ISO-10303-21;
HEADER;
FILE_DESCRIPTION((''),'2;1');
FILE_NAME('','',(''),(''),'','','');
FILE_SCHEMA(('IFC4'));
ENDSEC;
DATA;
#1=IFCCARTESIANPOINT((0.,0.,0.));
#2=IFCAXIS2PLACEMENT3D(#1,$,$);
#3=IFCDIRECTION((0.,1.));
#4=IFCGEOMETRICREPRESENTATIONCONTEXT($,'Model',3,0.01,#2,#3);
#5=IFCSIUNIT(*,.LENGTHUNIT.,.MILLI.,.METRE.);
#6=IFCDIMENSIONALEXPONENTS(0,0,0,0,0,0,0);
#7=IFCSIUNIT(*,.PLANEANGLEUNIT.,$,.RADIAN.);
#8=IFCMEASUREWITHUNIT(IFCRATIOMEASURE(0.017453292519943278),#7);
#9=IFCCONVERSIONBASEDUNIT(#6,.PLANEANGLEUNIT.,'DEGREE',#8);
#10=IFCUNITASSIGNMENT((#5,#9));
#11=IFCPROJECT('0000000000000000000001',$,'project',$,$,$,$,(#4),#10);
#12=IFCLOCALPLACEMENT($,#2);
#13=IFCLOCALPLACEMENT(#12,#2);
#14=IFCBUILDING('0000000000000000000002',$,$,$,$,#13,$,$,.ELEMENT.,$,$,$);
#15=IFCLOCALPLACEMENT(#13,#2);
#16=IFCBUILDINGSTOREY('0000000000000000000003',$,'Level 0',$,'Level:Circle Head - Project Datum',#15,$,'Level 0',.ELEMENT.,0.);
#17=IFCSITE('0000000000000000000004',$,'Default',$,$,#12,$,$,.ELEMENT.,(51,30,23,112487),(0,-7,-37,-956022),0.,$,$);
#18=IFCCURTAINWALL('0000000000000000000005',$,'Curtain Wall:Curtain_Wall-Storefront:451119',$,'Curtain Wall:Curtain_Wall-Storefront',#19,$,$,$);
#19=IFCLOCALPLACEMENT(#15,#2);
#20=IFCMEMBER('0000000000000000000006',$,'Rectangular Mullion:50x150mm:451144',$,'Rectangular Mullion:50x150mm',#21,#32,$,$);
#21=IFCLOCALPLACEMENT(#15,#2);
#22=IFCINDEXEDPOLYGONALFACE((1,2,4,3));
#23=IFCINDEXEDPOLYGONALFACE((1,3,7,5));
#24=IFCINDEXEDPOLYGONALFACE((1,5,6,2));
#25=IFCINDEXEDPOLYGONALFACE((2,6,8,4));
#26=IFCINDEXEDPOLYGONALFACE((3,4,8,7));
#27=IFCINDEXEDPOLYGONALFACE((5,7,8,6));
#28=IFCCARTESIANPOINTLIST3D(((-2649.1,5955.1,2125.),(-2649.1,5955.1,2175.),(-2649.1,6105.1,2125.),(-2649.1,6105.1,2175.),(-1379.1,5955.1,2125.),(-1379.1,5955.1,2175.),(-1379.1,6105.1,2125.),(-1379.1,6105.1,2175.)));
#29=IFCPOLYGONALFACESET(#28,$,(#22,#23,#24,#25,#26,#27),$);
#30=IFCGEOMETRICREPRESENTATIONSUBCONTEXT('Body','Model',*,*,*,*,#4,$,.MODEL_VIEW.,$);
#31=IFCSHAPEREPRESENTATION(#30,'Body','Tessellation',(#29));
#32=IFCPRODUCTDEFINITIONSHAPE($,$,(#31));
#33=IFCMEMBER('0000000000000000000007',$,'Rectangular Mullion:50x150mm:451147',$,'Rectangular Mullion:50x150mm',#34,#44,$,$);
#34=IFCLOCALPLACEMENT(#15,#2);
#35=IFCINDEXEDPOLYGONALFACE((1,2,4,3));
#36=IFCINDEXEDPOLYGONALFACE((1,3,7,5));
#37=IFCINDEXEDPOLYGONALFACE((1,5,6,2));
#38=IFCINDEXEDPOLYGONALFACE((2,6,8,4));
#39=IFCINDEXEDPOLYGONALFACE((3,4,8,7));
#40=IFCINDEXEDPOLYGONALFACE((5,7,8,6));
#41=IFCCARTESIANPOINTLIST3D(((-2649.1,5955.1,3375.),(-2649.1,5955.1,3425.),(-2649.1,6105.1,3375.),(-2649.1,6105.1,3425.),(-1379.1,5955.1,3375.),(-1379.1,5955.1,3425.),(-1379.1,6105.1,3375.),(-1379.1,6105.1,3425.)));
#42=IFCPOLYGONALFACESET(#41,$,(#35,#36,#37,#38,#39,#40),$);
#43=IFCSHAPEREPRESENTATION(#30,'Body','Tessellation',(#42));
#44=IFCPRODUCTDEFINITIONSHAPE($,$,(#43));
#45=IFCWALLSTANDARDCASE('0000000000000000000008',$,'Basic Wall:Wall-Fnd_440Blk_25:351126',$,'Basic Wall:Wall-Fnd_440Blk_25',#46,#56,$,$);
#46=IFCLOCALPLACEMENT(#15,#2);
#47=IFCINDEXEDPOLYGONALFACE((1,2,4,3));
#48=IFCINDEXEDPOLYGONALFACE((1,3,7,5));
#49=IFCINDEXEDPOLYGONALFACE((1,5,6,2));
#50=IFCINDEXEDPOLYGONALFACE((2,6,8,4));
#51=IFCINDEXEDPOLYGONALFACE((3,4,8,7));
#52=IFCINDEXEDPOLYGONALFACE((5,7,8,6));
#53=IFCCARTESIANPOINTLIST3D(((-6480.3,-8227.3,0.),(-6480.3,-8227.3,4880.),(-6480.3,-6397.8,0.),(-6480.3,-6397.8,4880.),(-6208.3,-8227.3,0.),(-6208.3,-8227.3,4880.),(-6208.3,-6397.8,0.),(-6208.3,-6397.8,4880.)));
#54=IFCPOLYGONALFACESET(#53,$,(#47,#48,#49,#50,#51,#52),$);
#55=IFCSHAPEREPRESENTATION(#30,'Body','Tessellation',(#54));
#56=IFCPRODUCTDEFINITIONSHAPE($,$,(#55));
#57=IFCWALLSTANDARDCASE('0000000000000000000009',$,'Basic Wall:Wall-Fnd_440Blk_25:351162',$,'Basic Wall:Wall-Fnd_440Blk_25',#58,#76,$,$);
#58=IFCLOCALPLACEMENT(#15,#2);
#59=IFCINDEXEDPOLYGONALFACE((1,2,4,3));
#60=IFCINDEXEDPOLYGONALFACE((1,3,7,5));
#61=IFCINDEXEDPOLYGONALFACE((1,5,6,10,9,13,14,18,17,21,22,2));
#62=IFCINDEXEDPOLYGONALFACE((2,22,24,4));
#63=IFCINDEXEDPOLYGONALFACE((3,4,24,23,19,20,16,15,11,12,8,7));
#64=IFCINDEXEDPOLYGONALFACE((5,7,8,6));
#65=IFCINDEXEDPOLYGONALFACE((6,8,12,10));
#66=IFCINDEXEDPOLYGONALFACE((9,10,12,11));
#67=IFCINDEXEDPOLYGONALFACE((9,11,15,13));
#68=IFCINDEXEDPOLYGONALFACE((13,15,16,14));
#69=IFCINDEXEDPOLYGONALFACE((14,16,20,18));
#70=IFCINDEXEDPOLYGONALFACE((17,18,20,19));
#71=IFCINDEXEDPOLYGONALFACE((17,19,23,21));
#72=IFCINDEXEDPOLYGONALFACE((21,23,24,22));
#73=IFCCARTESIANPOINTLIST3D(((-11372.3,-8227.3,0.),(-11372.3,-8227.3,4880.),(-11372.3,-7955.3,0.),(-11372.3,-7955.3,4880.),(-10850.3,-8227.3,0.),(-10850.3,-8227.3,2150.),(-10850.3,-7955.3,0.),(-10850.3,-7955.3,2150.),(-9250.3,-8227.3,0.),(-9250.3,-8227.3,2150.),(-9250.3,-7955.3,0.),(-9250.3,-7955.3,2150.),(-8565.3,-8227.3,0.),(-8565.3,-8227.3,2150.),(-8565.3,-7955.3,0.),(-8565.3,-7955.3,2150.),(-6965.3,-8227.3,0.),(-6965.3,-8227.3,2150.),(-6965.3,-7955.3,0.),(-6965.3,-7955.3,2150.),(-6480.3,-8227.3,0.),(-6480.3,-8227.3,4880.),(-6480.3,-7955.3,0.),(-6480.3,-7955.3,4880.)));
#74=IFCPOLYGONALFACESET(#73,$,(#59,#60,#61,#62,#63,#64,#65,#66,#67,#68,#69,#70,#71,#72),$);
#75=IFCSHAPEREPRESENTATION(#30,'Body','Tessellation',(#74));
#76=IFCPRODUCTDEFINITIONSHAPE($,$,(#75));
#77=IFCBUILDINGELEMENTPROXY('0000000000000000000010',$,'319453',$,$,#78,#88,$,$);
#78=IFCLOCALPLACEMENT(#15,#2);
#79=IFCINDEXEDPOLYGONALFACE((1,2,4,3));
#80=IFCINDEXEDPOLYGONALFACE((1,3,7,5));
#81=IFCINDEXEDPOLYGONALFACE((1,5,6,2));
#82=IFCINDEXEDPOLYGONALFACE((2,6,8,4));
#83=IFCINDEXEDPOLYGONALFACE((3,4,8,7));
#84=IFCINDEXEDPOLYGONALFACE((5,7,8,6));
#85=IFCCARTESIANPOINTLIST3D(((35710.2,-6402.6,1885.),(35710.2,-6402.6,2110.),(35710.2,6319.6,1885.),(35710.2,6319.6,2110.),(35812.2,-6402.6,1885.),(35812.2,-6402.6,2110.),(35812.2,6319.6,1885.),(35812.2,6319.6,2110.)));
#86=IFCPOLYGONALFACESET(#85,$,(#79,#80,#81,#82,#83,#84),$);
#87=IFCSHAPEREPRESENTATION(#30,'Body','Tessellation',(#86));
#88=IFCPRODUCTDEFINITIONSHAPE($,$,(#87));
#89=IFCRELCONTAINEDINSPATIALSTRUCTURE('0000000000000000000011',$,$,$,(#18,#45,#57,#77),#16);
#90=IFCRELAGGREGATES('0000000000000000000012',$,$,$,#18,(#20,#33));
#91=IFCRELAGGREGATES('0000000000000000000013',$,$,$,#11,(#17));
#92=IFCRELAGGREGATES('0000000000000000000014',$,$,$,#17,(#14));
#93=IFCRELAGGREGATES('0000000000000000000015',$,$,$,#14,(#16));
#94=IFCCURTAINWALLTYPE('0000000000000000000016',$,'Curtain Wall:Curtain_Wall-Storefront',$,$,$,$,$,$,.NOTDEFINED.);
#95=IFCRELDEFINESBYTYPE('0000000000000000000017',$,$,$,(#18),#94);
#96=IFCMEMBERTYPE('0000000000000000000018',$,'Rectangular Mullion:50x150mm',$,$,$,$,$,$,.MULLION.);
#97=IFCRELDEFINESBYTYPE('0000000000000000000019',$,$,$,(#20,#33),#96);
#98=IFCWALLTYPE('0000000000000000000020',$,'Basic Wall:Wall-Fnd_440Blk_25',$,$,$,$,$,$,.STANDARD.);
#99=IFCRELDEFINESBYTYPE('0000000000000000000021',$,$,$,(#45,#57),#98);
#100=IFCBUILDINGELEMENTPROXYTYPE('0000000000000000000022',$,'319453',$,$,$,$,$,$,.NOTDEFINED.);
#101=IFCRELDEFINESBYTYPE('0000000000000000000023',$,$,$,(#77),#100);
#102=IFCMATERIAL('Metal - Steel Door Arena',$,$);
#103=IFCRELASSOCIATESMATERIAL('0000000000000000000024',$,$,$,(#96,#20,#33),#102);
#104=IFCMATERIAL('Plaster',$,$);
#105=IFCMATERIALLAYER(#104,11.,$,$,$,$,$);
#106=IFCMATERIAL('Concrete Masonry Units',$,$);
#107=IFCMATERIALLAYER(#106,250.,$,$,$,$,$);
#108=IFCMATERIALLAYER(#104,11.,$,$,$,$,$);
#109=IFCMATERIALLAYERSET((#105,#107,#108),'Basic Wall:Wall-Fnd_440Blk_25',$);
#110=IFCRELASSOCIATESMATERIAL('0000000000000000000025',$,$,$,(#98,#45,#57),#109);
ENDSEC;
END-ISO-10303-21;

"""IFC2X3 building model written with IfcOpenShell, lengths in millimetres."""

from ifc_helpers import new_model, entity, si_unit, converted_unit, direction, frame, frame_2d, origin, origin_2d_with_axis, place, context, subcontext, project, spatial, polyline, rectangle, extrude, clip, bounded_halfspace, source, transform, mapped, material, layer, layer_set, layer_usage, type_object, type_shapes, element, aggregate, save


model = new_model("IFC2X3")

# Units and contexts
model_context = context("Model", 3, precision=0.01, world=origin(), true_north=direction((0.0, 1.0)))
body_context = subcontext(model_context, "Body", "Model", "MODEL_VIEW")
ifc_project = project(units=[si_unit("LENGTHUNIT", "METRE", prefix="MILLI"), converted_unit("PLANEANGLEUNIT", "DEGREE", entity("IfcRatioMeasure", 0.017453292519943278), si_unit("PLANEANGLEUNIT", "RADIAN"), dimensions=[0, 0, 0, 0, 0, 0, 0])], contexts=[model_context])

# Site, building, storey
site_placement = place(None, origin())
site = spatial("IfcSite", under=ifc_project, at=site_placement, Name="Default", CompositionType="ELEMENT", RefLatitude=(51, 30, 23, 112487), RefLongitude=(0, -7, -37, -956022), RefElevation=0.0)
building_placement = place(site_placement, origin())
building = spatial("IfcBuilding", under=site, at=building_placement, CompositionType="ELEMENT")
storey_placement = place(building_placement, origin())
storey = spatial("IfcBuildingStorey", under=building, at=storey_placement, Name="Level 0", ObjectType="Level:Circle Head - Project Datum", LongName="Level 0", CompositionType="ELEMENT", Elevation=0.0)

# Shared definitions
ifc_material_1 = material(Name="Plaster")

# Curtain wall, members
curtain_wall_type = type_object("IfcCurtainWallType", Name="Curtain Wall:Curtain_Wall-Storefront", PredefinedType="NOTDEFINED")
curtain_wall_placement = place(storey_placement, origin())
curtain_wall = element("IfcCurtainWall", 1, at=curtain_wall_placement, inside=storey, type_object=curtain_wall_type, Name="Curtain Wall:Curtain_Wall-Storefront:451119", ObjectType="Curtain Wall:Curtain_Wall-Storefront")
ifc_material_2 = material(Name="Metal - Steel Door Arena")
member_type_1 = type_object("IfcMemberType", Name="Rectangular Mullion:50x150mm", PredefinedType="MULLION", material=ifc_material_2)
shared_shape_1 = source(origin(), body_context, "Body", "SweptSolid", [
    extrude(rectangle(XDim=150.0, YDim=50.0, at=origin_2d_with_axis()), frame((0.0, 0.0, -1270.0), z_axis=(0.0, 0.0, 1.0), x_axis=(0.0, -1.0, 0.0)), (0.0, 0.0, 1.0), 1270.0),
])
type_shapes(member_type_1, [shared_shape_1])
member_1_placement = place(curtain_wall_placement, frame((-2649.1, 6030.1, 2150.0), z_axis=(-1.0, 0.0, 0.0), x_axis=(0.0, 0.0, 1.0)))
member_1 = element("IfcMember", 2, at=member_1_placement, type_object=member_type_1, material=ifc_material_2, Name="Rectangular Mullion:50x150mm:451144", ObjectType="Rectangular Mullion:50x150mm", context=body_context, shape_type="MappedRepresentation", body=[
    mapped(shared_shape_1, transform((0.0, 0.0, 0.0), scale=1.0)),
])
member_2_placement = place(curtain_wall_placement, frame((-2649.1, 6030.1, 3400.0), z_axis=(-1.0, 0.0, 0.0), x_axis=(0.0, 0.0, 1.0)))
member_2 = element("IfcMember", 3, at=member_2_placement, type_object=member_type_1, material=ifc_material_2, Name="Rectangular Mullion:50x150mm:451147", ObjectType="Rectangular Mullion:50x150mm", context=body_context, shape_type="MappedRepresentation", body=[
    mapped(shared_shape_1, transform((0.0, 0.0, 0.0), scale=1.0)),
])

aggregate(curtain_wall, [member_1, member_2])

# Wall
ifc_layer_1 = layer(ifc_material_1, 11.0)
ifc_material_3 = material(Name="Concrete Masonry Units")
ifc_layer_2 = layer(ifc_material_3, 250.0)
ifc_layer_3 = layer(ifc_material_1, 11.0)
ifc_layer_set_1 = layer_set([ifc_layer_1, ifc_layer_2, ifc_layer_3], Name="Basic Wall:Wall-Fnd_440Blk_25")
ifc_layer_usage_1 = layer_usage(ifc_layer_set_1, "AXIS2", "NEGATIVE", 136.0)
wall_type_1 = type_object("IfcWallType", Name="Basic Wall:Wall-Fnd_440Blk_25", PredefinedType="STANDARD", material=ifc_layer_set_1)
wall_1_placement = place(storey_placement, frame((-6344.3, -6397.8, 0.0), z_axis=(0.0, 0.0, 1.0), x_axis=(0.0, -1.0, 0.0)))
element("IfcWallStandardCase", 4, at=wall_1_placement, inside=storey, type_object=wall_type_1, material=ifc_layer_usage_1, Name="Basic Wall:Wall-Fnd_440Blk_25:351126", ObjectType="Basic Wall:Wall-Fnd_440Blk_25", context=body_context, shape_type="SweptSolid", body=[
    extrude(rectangle(XDim=1829.5, YDim=272.0, at=frame_2d((914.8, 0.0), x_axis=(-1.0, 0.0))), origin(), (0.0, 0.0, 1.0), 4880.0),
])

# Wall, openings
ifc_layer_usage_2 = layer_usage(ifc_layer_set_1, "AXIS2", "NEGATIVE", 136.0)
wall_2_placement = place(storey_placement, frame((-6480.3, -8091.3, 0.0), z_axis=(0.0, 0.0, 1.0), x_axis=(-1.0, 0.0, 0.0)))
wall_2 = element("IfcWallStandardCase", 5, at=wall_2_placement, inside=storey, type_object=wall_type_1, material=ifc_layer_usage_2, Name="Basic Wall:Wall-Fnd_440Blk_25:351162", ObjectType="Basic Wall:Wall-Fnd_440Blk_25", context=body_context, shape_type="Clipping", body=[
    clip(extrude(rectangle(XDim=4892.0, YDim=272.0, at=frame_2d((2446.0, 0.0), x_axis=(1.0, 0.0))), origin(), (0.0, 0.0, 1.0), 4880.0), bounded_halfspace(frame((0.0, -136.0, 4880.0), z_axis=(0.0, 0.0, -1.0), x_axis=(-1.0, 0.0, 0.0)), True, frame((0.0, -136.0, 4880.0)), polyline([(0.0, 0.0), (1408176.0, 0.0), (1491081.6, 0.0), (1491081.6, 82905.6), (0.0, 82905.6), (0.0, 0.0)]))),
])
opening_1_placement = place(wall_2_placement, frame((2085.0, 136.0, 0.0)))
element("IfcOpeningElement", 6, at=opening_1_placement, cuts=wall_2, ObjectType="Opening", context=body_context, shape_type="SweptSolid", body=[
    extrude(rectangle(XDim=2150.0, YDim=1600.0, at=frame_2d((1075.0, 800.0), x_axis=(1.0, 0.0))), frame((0.0, 0.0, 0.0), z_axis=(0.0, -1.0, 0.0), x_axis=(0.0, 0.0, 1.0)), (0.0, 0.0, 1.0), 272.0),
])
opening_2_placement = place(wall_2_placement, frame((4370.0, 136.0, 0.0)))
element("IfcOpeningElement", 7, at=opening_2_placement, cuts=wall_2, ObjectType="Opening", context=body_context, shape_type="SweptSolid", body=[
    extrude(rectangle(XDim=2150.0, YDim=1600.0, at=frame_2d((1075.0, 800.0), x_axis=(1.0, 0.0))), frame((0.0, 0.0, 0.0), z_axis=(0.0, -1.0, 0.0), x_axis=(0.0, 0.0, 1.0)), (0.0, 0.0, 1.0), 272.0),
])

# Building element proxy
building_element_proxy_type_1 = type_object("IfcBuildingElementProxyType", Name="319453", PredefinedType="NOTDEFINED")
proxy_1_placement = place(storey_placement, origin())
element("IfcBuildingElementProxy", 8, at=proxy_1_placement, inside=storey, type_object=building_element_proxy_type_1, Name="319453", context=body_context, shape_type="SweptSolid", body=[
    extrude(rectangle(XDim=12722.3, YDim=102.0, at=frame_2d((0.0, 0.0), x_axis=(1.0, 0.0))), frame((35761.2, -41.5, 1885.0), z_axis=(0.0, 0.0, 1.0), x_axis=(0.0, -1.0, 0.0)), (0.0, 0.0, 1.0), 225.0),
])

save(model, "model.ifc")
